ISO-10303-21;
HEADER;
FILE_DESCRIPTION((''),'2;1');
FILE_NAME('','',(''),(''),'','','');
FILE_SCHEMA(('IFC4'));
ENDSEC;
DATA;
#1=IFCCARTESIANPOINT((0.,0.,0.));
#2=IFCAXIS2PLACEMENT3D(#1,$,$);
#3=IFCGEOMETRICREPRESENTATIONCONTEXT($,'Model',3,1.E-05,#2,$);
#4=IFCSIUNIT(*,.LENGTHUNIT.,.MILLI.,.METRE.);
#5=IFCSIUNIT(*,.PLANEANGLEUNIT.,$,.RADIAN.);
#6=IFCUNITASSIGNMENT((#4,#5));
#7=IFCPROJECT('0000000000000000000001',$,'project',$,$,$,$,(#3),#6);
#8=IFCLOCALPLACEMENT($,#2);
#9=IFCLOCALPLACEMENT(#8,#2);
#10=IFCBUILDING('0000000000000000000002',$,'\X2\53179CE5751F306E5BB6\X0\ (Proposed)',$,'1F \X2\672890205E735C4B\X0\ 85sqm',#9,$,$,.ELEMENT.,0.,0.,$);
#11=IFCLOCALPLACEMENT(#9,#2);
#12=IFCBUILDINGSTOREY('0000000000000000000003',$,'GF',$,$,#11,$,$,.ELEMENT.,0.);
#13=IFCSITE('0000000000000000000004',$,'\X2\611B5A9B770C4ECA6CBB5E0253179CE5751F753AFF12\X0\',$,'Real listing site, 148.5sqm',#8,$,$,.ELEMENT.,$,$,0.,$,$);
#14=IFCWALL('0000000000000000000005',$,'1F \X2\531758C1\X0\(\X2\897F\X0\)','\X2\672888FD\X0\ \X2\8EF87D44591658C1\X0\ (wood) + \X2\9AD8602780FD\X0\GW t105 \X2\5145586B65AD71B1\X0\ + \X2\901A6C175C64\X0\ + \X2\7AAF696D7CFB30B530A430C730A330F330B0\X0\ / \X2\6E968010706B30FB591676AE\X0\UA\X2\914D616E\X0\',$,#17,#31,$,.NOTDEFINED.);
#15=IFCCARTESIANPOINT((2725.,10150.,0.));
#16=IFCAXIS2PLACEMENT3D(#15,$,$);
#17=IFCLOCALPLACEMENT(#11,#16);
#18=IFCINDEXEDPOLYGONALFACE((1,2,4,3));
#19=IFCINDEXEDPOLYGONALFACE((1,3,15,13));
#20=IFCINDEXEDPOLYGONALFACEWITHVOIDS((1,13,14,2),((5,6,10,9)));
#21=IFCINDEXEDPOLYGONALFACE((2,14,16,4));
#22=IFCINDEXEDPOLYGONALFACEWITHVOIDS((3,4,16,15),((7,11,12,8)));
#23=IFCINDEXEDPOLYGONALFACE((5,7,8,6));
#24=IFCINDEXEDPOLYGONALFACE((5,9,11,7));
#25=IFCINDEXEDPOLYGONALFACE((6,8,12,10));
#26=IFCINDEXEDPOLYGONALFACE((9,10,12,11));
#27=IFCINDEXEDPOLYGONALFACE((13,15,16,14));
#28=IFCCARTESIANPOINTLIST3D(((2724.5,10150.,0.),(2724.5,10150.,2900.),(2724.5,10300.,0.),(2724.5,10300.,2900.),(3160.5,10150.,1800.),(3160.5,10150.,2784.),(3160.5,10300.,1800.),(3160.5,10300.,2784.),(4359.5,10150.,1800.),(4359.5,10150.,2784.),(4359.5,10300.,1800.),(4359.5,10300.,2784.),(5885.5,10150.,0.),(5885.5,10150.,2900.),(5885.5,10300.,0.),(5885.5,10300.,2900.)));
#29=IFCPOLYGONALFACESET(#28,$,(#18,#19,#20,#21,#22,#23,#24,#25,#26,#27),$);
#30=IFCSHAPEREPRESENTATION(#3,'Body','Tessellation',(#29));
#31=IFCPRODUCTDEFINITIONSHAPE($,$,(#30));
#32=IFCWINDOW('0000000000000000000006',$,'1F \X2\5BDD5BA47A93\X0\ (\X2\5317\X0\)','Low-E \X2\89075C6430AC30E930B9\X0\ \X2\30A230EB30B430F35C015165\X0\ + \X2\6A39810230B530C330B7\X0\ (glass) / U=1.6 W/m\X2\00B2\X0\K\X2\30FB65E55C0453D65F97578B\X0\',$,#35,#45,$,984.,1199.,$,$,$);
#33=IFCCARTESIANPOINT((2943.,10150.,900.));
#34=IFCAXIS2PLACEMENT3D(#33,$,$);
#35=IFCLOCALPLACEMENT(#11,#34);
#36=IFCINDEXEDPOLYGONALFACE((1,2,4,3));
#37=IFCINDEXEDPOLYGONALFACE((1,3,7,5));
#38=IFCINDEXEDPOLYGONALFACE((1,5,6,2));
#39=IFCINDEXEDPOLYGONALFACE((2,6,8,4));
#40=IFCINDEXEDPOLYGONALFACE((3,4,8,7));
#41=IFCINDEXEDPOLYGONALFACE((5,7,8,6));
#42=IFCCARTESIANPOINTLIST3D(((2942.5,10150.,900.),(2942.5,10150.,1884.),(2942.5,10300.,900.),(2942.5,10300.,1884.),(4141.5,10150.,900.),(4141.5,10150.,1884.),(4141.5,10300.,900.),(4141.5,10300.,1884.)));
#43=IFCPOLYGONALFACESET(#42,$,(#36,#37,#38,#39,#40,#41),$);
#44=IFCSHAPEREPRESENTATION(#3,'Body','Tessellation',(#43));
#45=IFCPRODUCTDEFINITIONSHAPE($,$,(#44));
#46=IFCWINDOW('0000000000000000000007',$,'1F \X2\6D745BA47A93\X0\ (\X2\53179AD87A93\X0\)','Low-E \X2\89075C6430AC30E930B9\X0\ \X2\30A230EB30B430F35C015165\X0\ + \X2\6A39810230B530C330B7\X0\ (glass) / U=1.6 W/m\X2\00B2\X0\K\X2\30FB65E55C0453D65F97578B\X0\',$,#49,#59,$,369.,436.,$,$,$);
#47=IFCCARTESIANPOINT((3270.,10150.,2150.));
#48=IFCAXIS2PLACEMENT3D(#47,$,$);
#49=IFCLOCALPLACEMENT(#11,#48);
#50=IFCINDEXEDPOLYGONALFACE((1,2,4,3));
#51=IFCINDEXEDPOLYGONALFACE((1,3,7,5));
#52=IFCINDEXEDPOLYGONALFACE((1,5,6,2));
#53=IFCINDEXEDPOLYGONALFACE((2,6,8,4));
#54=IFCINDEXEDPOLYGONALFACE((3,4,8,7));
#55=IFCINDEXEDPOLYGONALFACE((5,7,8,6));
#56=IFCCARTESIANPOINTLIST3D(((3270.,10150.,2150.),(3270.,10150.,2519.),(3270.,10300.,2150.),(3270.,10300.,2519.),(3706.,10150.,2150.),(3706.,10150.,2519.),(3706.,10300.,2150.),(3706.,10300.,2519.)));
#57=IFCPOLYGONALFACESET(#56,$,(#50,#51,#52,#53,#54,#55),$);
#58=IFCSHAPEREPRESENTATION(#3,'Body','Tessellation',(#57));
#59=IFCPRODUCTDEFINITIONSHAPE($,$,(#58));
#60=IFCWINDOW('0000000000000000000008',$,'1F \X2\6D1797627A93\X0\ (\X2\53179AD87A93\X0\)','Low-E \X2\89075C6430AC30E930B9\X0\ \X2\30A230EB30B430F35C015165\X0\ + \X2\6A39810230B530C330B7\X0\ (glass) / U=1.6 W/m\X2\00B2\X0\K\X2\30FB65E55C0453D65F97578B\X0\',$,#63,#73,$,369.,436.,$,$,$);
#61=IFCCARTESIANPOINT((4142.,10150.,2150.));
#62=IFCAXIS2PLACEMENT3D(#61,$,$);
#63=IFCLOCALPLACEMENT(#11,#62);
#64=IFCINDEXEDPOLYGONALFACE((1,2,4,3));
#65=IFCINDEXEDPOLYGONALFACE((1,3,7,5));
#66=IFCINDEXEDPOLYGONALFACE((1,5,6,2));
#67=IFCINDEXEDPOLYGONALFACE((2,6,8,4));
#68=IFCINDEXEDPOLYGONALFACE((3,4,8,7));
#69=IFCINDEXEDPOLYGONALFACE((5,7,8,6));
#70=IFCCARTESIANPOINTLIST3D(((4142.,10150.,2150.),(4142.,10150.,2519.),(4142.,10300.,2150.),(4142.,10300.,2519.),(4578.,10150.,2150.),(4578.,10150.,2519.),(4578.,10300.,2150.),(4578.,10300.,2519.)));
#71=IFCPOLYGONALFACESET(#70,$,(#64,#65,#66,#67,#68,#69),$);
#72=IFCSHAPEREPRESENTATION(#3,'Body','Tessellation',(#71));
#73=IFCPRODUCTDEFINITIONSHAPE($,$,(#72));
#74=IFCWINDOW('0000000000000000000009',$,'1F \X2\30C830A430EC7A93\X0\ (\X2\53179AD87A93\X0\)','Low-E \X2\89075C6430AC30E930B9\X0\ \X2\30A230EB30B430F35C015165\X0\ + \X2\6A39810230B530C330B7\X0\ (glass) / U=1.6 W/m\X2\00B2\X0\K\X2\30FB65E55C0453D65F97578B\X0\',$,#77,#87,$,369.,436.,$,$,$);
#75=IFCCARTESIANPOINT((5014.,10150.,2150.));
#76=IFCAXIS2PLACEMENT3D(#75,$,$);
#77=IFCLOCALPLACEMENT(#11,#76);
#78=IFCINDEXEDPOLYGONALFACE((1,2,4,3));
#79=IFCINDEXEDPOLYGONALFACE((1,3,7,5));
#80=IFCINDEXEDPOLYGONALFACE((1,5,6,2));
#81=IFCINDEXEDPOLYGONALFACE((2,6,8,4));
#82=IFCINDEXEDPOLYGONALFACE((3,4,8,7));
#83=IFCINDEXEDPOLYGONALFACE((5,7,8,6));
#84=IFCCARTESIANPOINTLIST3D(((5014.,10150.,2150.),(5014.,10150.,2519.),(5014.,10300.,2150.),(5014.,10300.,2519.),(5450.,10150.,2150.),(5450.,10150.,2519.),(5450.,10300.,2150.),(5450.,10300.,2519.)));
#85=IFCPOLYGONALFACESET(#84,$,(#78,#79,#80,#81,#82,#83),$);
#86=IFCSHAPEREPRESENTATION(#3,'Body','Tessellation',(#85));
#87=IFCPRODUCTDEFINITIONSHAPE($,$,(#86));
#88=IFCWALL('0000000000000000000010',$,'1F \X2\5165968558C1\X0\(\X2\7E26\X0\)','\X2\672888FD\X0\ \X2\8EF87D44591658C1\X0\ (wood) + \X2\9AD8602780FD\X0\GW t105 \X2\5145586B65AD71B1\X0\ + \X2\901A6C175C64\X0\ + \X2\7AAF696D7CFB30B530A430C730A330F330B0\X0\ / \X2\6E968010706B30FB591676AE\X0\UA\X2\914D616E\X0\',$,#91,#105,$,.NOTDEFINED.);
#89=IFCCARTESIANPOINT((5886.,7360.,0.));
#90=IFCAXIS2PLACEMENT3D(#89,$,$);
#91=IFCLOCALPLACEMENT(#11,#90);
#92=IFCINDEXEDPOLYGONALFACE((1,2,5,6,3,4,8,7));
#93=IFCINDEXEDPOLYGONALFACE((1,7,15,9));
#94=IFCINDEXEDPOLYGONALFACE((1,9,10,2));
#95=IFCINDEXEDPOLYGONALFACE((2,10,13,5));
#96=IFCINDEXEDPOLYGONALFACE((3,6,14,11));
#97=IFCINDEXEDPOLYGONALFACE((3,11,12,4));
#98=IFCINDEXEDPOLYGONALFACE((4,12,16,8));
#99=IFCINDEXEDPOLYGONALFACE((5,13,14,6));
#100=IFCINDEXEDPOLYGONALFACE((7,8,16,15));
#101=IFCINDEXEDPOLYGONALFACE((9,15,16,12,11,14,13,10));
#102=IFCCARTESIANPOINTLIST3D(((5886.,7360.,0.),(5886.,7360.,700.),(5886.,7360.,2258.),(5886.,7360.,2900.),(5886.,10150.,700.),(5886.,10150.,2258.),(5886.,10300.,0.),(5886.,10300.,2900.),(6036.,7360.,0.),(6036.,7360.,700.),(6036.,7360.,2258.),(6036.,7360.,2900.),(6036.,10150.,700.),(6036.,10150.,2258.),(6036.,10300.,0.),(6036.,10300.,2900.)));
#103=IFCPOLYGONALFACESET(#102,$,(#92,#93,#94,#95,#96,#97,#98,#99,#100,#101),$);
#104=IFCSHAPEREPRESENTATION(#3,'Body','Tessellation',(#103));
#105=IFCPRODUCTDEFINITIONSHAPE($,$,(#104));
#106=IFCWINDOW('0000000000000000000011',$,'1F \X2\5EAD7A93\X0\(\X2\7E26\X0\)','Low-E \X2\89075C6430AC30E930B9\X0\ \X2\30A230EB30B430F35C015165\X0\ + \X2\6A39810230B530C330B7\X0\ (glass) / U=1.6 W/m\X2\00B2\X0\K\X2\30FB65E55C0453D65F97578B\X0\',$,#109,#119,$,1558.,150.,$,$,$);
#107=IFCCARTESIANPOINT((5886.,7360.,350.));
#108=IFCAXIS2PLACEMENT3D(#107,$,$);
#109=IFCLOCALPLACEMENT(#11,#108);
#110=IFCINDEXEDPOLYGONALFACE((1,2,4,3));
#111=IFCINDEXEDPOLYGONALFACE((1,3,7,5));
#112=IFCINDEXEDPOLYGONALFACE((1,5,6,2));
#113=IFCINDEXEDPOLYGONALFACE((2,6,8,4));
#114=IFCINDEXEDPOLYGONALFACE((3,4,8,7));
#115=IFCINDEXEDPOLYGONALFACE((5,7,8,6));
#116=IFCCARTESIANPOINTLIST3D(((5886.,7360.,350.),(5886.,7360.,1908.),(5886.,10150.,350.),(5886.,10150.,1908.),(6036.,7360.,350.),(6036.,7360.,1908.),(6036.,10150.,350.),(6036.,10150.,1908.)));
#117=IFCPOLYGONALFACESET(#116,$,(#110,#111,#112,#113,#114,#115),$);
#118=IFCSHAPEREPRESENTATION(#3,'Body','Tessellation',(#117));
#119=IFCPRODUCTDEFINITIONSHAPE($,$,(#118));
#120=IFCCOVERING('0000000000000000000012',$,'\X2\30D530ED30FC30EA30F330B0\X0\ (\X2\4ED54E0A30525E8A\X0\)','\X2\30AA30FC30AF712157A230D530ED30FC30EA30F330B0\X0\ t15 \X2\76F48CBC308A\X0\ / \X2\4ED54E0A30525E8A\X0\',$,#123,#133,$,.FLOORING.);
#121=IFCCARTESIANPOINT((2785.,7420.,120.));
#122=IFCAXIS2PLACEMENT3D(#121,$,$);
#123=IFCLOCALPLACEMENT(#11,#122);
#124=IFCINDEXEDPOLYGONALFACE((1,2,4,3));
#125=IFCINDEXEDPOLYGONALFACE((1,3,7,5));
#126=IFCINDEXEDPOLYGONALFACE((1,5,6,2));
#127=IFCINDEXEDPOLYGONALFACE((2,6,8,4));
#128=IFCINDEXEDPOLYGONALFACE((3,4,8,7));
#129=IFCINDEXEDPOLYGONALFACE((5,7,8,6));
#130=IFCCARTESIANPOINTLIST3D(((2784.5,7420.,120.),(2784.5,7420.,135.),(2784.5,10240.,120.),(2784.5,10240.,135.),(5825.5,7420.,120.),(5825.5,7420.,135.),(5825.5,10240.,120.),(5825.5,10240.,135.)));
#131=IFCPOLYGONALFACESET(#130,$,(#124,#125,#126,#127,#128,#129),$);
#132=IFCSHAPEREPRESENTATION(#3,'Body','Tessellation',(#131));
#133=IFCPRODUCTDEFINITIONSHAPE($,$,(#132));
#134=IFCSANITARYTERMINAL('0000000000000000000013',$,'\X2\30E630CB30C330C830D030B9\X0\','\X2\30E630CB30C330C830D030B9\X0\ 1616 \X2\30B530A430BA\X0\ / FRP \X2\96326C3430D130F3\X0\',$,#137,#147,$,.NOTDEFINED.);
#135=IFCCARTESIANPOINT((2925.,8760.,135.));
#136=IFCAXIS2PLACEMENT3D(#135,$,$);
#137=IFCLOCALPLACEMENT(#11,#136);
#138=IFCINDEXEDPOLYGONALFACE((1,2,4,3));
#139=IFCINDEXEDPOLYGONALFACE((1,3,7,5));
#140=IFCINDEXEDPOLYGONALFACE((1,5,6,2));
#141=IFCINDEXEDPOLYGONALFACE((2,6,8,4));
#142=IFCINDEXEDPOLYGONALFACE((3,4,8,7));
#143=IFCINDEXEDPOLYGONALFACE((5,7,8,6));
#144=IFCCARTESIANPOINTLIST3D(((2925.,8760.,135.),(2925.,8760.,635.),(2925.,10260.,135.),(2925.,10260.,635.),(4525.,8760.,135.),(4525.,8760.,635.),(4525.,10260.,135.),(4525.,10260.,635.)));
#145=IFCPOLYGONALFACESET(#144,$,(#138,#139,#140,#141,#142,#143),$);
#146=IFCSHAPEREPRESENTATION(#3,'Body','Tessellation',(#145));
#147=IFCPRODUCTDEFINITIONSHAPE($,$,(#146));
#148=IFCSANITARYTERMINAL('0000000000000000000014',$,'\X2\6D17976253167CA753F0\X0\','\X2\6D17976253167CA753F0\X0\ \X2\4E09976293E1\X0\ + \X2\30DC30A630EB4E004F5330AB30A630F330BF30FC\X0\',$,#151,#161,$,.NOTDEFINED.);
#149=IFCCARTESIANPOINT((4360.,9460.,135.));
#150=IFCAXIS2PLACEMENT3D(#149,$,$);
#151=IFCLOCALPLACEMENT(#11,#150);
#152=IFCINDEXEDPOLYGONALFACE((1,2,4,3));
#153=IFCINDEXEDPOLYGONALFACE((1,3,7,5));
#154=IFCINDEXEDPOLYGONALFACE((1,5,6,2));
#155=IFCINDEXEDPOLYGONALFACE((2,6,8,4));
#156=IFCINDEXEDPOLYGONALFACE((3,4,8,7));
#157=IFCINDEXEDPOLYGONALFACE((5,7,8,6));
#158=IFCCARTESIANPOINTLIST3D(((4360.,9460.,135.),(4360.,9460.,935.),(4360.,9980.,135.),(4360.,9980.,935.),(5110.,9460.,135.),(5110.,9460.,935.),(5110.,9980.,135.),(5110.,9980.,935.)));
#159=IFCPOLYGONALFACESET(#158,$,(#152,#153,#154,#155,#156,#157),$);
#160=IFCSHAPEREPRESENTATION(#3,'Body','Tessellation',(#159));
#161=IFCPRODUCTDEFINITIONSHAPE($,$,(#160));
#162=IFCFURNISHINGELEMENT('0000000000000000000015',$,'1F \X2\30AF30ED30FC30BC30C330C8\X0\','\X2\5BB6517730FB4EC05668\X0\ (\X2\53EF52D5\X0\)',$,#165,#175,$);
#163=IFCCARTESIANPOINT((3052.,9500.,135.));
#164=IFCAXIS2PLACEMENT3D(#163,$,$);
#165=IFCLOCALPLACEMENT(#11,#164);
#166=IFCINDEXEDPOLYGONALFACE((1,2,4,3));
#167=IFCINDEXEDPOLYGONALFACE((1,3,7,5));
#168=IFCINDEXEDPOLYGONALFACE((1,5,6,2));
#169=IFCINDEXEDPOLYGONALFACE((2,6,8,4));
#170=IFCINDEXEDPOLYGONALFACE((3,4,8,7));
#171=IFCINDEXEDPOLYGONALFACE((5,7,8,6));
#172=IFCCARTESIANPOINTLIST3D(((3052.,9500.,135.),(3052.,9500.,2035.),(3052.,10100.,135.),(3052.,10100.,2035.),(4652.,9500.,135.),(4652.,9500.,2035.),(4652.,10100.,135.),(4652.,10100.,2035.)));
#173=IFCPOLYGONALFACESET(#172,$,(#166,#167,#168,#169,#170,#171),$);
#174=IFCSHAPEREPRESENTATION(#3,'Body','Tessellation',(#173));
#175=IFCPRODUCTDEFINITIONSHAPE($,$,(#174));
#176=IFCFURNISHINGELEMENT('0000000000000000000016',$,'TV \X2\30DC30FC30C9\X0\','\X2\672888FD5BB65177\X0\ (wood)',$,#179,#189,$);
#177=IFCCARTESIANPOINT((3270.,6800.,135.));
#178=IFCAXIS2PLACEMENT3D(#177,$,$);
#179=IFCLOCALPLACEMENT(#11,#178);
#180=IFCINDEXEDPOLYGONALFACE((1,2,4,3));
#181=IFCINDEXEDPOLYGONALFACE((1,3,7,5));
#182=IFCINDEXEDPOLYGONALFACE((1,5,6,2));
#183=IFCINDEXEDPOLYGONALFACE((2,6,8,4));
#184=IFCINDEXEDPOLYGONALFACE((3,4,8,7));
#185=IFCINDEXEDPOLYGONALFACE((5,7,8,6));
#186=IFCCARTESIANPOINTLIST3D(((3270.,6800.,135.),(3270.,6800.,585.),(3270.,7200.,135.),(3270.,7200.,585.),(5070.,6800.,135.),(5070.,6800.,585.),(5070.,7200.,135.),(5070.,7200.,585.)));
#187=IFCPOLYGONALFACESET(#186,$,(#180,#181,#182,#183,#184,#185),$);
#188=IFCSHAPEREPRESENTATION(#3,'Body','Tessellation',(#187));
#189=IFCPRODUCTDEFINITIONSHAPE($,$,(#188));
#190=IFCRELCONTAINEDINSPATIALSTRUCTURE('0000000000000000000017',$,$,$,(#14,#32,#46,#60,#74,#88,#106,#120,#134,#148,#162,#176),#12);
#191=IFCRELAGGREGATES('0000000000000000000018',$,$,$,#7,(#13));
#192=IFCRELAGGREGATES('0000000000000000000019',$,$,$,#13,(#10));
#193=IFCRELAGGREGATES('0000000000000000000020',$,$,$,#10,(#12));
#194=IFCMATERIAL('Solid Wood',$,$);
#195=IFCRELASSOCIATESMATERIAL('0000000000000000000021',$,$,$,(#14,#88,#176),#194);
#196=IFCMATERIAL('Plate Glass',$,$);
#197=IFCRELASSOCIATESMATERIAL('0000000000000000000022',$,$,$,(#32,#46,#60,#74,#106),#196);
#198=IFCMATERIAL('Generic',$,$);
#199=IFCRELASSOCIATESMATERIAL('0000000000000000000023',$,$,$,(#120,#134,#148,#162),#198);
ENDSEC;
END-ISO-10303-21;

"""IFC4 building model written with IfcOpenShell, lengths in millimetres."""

from ifc_helpers import new_model, si_unit, frame, frame_2d, origin, place, context, project, spatial, rectangle, extrude, material, element, fill, save


model = new_model("IFC4")

# Units and contexts
model_context = context("Model", 3, precision=1e-05, world=origin())
ifc_project = project(units=[si_unit("LENGTHUNIT", "METRE", prefix="MILLI"), si_unit("PLANEANGLEUNIT", "RADIAN")], contexts=[model_context])

# Site, building, storey
site_placement = place(None, origin())
site = spatial("IfcSite", under=ifc_project, at=site_placement, Name="愛媛県今治市北鳥生町２", ObjectType="Real listing site, 148.5sqm", CompositionType="ELEMENT", RefElevation=0.0)
building_placement = place(site_placement, origin())
building = spatial("IfcBuilding", under=site, at=building_placement, Name="北鳥生の家 (Proposed)", ObjectType="1F 木造平屋 85sqm", CompositionType="ELEMENT", ElevationOfRefHeight=0.0, ElevationOfTerrain=0.0)
storey_placement = place(building_placement, origin())
storey = spatial("IfcBuildingStorey", under=building, at=storey_placement, Name="GF", CompositionType="ELEMENT", Elevation=0.0)

# Shared definitions
ifc_material_1 = material(Name="Solid Wood")

# Wall, openings, windows
wall_1_placement = place(storey_placement, frame((2725.0, 10150.0, 0.0)))
wall_1 = element("IfcWall", 1, at=wall_1_placement, inside=storey, material=ifc_material_1, Name="1F 北壁(西)", Description="木製 軸組外壁 (wood) + 高性能GW t105 充填断熱 + 通気層 + 窯業系サイディング / 準耐火・外皮UA配慮", PredefinedType="NOTDEFINED", context=model_context, shape_type="SweptSolid", body=[
    extrude(rectangle(XDim=3161.0, YDim=150.0, at=frame_2d((1580.0, 75.0))), frame((2725.0, 10150.0, 0.0)), (0.0, 0.0, 1.0), 2900.0),
])
opening_1_placement = place(storey_placement, frame((2943.0, 10150.0, 900.0)))
opening_1 = element("IfcOpeningElement", 2, at=opening_1_placement, cuts=wall_1, PredefinedType="NOTDEFINED", context=model_context, shape_type="SweptSolid", body=[
    extrude(rectangle(XDim=1199.0, YDim=150.0, at=frame_2d((599.0, 75.0))), frame((2943.0, 10150.0, 900.0)), (0.0, 0.0, 1.0), 984.0),
])
opening_2_placement = place(storey_placement, frame((3270.0, 10150.0, 2150.0)))
opening_2 = element("IfcOpeningElement", 3, at=opening_2_placement, cuts=wall_1, PredefinedType="NOTDEFINED", context=model_context, shape_type="SweptSolid", body=[
    extrude(rectangle(XDim=436.0, YDim=150.0, at=frame_2d((218.0, 75.0))), frame((3270.0, 10150.0, 2150.0)), (0.0, 0.0, 1.0), 369.0),
])
opening_3_placement = place(storey_placement, frame((4142.0, 10150.0, 2150.0)))
opening_3 = element("IfcOpeningElement", 4, at=opening_3_placement, cuts=wall_1, PredefinedType="NOTDEFINED", context=model_context, shape_type="SweptSolid", body=[
    extrude(rectangle(XDim=436.0, YDim=150.0, at=frame_2d((218.0, 75.0))), frame((4142.0, 10150.0, 2150.0)), (0.0, 0.0, 1.0), 369.0),
])
opening_4_placement = place(storey_placement, frame((5014.0, 10150.0, 2150.0)))
opening_4 = element("IfcOpeningElement", 5, at=opening_4_placement, cuts=wall_1, PredefinedType="NOTDEFINED", context=model_context, shape_type="SweptSolid", body=[
    extrude(rectangle(XDim=436.0, YDim=150.0, at=frame_2d((218.0, 75.0))), frame((5014.0, 10150.0, 2150.0)), (0.0, 0.0, 1.0), 369.0),
])
ifc_material_2 = material(Name="Plate Glass")
window_1_placement = place(storey_placement, frame((2943.0, 10150.0, 900.0)))
window_1 = element("IfcWindow", 6, at=window_1_placement, inside=storey, material=ifc_material_2, Name="1F 寝室窓 (北)", Description="Low-E 複層ガラス アルゴン封入 + 樹脂サッシ (glass) / U=1.6 W/m²K・日射取得型", OverallHeight=984.0, OverallWidth=1199.0, context=model_context, shape_type="SweptSolid", body=[
    extrude(rectangle(XDim=1199.0, YDim=150.0, at=frame_2d((599.0, 75.0))), frame((2943.0, 10150.0, 900.0)), (0.0, 0.0, 1.0), 984.0),
])
fill(opening_1, window_1)
window_2_placement = place(storey_placement, frame((3270.0, 10150.0, 2150.0)))
window_2 = element("IfcWindow", 7, at=window_2_placement, inside=storey, material=ifc_material_2, Name="1F 浴室窓 (北高窓)", Description="Low-E 複層ガラス アルゴン封入 + 樹脂サッシ (glass) / U=1.6 W/m²K・日射取得型", OverallHeight=369.0, OverallWidth=436.0, context=model_context, shape_type="SweptSolid", body=[
    extrude(rectangle(XDim=436.0, YDim=150.0, at=frame_2d((218.0, 75.0))), frame((3270.0, 10150.0, 2150.0)), (0.0, 0.0, 1.0), 369.0),
])
fill(opening_2, window_2)
window_3_placement = place(storey_placement, frame((4142.0, 10150.0, 2150.0)))
window_3 = element("IfcWindow", 8, at=window_3_placement, inside=storey, material=ifc_material_2, Name="1F 洗面窓 (北高窓)", Description="Low-E 複層ガラス アルゴン封入 + 樹脂サッシ (glass) / U=1.6 W/m²K・日射取得型", OverallHeight=369.0, OverallWidth=436.0, context=model_context, shape_type="SweptSolid", body=[
    extrude(rectangle(XDim=436.0, YDim=150.0, at=frame_2d((218.0, 75.0))), frame((4142.0, 10150.0, 2150.0)), (0.0, 0.0, 1.0), 369.0),
])
fill(opening_3, window_3)
window_4_placement = place(storey_placement, frame((5014.0, 10150.0, 2150.0)))
window_4 = element("IfcWindow", 9, at=window_4_placement, inside=storey, material=ifc_material_2, Name="1F トイレ窓 (北高窓)", Description="Low-E 複層ガラス アルゴン封入 + 樹脂サッシ (glass) / U=1.6 W/m²K・日射取得型", OverallHeight=369.0, OverallWidth=436.0, context=model_context, shape_type="SweptSolid", body=[
    extrude(rectangle(XDim=436.0, YDim=150.0, at=frame_2d((218.0, 75.0))), frame((5014.0, 10150.0, 2150.0)), (0.0, 0.0, 1.0), 369.0),
])
fill(opening_4, window_4)

# Wall, opening, window
wall_2_placement = place(storey_placement, frame((5886.0, 7360.0, 0.0)))
wall_2 = element("IfcWall", 10, at=wall_2_placement, inside=storey, material=ifc_material_1, Name="1F 入隅壁(縦)", Description="木製 軸組外壁 (wood) + 高性能GW t105 充填断熱 + 通気層 + 窯業系サイディング / 準耐火・外皮UA配慮", PredefinedType="NOTDEFINED", context=model_context, shape_type="SweptSolid", body=[
    extrude(rectangle(XDim=150.0, YDim=2940.0, at=frame_2d((75.0, 1470.0))), frame((5886.0, 7360.0, 0.0)), (0.0, 0.0, 1.0), 2900.0),
])
opening_5_placement = place(storey_placement, frame((5886.0, 7360.0, 350.0)))
opening_5 = element("IfcOpeningElement", 11, at=opening_5_placement, cuts=wall_2, PredefinedType="NOTDEFINED", context=model_context, shape_type="SweptSolid", body=[
    extrude(rectangle(XDim=150.0, YDim=2790.0, at=frame_2d((75.0, 1395.0))), frame((5886.0, 7360.0, 350.0)), (0.0, 0.0, 1.0), 1558.0),
])
window_5_placement = place(storey_placement, frame((5886.0, 7360.0, 350.0)))
window_5 = element("IfcWindow", 12, at=window_5_placement, inside=storey, material=ifc_material_2, Name="1F 庭窓(縦)", Description="Low-E 複層ガラス アルゴン封入 + 樹脂サッシ (glass) / U=1.6 W/m²K・日射取得型", OverallHeight=1558.0, OverallWidth=150.0, context=model_context, shape_type="SweptSolid", body=[
    extrude(rectangle(XDim=150.0, YDim=2790.0, at=frame_2d((75.0, 1395.0))), frame((5886.0, 7360.0, 350.0)), (0.0, 0.0, 1.0), 1558.0),
])
fill(opening_5, window_5)

# Covering
ifc_material_3 = material(Name="Generic")
covering_placement = place(storey_placement, frame((2785.0, 7420.0, 120.0)))
element("IfcCovering", 13, at=covering_placement, inside=storey, material=ifc_material_3, Name="フローリング (仕上げ床)", Description="オーク無垢フローリング t15 直貼り / 仕上げ床", PredefinedType="FLOORING", context=model_context, shape_type="SweptSolid", body=[
    extrude(rectangle(XDim=3041.0, YDim=2820.0, at=frame_2d((1520.0, 1410.0))), frame((2785.0, 7420.0, 120.0)), (0.0, 0.0, 1.0), 15.0),
])

# Sanitary terminals
sanitary_terminal_1_placement = place(storey_placement, frame((2925.0, 8760.0, 135.0)))
element("IfcSanitaryTerminal", 14, at=sanitary_terminal_1_placement, inside=storey, material=ifc_material_3, Name="ユニットバス", Description="ユニットバス 1616 サイズ / FRP 防水パン", PredefinedType="NOTDEFINED", context=model_context, shape_type="SweptSolid", body=[
    extrude(rectangle(XDim=1600.0, YDim=1500.0, at=frame_2d((800.0, 750.0))), frame((2925.0, 8760.0, 135.0)), (0.0, 0.0, 1.0), 500.0),
])
sanitary_terminal_2_placement = place(storey_placement, frame((4360.0, 9460.0, 135.0)))
element("IfcSanitaryTerminal", 15, at=sanitary_terminal_2_placement, inside=storey, material=ifc_material_3, Name="洗面化粧台", Description="洗面化粧台 三面鏡 + ボウル一体カウンター", PredefinedType="NOTDEFINED", context=model_context, shape_type="SweptSolid", body=[
    extrude(rectangle(XDim=750.0, YDim=520.0, at=frame_2d((375.0, 260.0))), frame((4360.0, 9460.0, 135.0)), (0.0, 0.0, 1.0), 800.0),
])

# Furnishing elements
furnishing_1_placement = place(storey_placement, frame((3052.0, 9500.0, 135.0)))
element("IfcFurnishingElement", 16, at=furnishing_1_placement, inside=storey, material=ifc_material_3, Name="1F クローゼット", Description="家具・什器 (可動)", context=model_context, shape_type="SweptSolid", body=[
    extrude(rectangle(XDim=1600.0, YDim=600.0, at=frame_2d((800.0, 300.0))), frame((3052.0, 9500.0, 135.0)), (0.0, 0.0, 1.0), 1900.0),
])
furnishing_2_placement = place(storey_placement, frame((3270.0, 6800.0, 135.0)))
element("IfcFurnishingElement", 17, at=furnishing_2_placement, inside=storey, material=ifc_material_1, Name="TV ボード", Description="木製家具 (wood)", context=model_context, shape_type="SweptSolid", body=[
    extrude(rectangle(XDim=1800.0, YDim=400.0, at=frame_2d((900.0, 200.0))), frame((3270.0, 6800.0, 135.0)), (0.0, 0.0, 1.0), 450.0),
])

save(model, "model.ifc")
